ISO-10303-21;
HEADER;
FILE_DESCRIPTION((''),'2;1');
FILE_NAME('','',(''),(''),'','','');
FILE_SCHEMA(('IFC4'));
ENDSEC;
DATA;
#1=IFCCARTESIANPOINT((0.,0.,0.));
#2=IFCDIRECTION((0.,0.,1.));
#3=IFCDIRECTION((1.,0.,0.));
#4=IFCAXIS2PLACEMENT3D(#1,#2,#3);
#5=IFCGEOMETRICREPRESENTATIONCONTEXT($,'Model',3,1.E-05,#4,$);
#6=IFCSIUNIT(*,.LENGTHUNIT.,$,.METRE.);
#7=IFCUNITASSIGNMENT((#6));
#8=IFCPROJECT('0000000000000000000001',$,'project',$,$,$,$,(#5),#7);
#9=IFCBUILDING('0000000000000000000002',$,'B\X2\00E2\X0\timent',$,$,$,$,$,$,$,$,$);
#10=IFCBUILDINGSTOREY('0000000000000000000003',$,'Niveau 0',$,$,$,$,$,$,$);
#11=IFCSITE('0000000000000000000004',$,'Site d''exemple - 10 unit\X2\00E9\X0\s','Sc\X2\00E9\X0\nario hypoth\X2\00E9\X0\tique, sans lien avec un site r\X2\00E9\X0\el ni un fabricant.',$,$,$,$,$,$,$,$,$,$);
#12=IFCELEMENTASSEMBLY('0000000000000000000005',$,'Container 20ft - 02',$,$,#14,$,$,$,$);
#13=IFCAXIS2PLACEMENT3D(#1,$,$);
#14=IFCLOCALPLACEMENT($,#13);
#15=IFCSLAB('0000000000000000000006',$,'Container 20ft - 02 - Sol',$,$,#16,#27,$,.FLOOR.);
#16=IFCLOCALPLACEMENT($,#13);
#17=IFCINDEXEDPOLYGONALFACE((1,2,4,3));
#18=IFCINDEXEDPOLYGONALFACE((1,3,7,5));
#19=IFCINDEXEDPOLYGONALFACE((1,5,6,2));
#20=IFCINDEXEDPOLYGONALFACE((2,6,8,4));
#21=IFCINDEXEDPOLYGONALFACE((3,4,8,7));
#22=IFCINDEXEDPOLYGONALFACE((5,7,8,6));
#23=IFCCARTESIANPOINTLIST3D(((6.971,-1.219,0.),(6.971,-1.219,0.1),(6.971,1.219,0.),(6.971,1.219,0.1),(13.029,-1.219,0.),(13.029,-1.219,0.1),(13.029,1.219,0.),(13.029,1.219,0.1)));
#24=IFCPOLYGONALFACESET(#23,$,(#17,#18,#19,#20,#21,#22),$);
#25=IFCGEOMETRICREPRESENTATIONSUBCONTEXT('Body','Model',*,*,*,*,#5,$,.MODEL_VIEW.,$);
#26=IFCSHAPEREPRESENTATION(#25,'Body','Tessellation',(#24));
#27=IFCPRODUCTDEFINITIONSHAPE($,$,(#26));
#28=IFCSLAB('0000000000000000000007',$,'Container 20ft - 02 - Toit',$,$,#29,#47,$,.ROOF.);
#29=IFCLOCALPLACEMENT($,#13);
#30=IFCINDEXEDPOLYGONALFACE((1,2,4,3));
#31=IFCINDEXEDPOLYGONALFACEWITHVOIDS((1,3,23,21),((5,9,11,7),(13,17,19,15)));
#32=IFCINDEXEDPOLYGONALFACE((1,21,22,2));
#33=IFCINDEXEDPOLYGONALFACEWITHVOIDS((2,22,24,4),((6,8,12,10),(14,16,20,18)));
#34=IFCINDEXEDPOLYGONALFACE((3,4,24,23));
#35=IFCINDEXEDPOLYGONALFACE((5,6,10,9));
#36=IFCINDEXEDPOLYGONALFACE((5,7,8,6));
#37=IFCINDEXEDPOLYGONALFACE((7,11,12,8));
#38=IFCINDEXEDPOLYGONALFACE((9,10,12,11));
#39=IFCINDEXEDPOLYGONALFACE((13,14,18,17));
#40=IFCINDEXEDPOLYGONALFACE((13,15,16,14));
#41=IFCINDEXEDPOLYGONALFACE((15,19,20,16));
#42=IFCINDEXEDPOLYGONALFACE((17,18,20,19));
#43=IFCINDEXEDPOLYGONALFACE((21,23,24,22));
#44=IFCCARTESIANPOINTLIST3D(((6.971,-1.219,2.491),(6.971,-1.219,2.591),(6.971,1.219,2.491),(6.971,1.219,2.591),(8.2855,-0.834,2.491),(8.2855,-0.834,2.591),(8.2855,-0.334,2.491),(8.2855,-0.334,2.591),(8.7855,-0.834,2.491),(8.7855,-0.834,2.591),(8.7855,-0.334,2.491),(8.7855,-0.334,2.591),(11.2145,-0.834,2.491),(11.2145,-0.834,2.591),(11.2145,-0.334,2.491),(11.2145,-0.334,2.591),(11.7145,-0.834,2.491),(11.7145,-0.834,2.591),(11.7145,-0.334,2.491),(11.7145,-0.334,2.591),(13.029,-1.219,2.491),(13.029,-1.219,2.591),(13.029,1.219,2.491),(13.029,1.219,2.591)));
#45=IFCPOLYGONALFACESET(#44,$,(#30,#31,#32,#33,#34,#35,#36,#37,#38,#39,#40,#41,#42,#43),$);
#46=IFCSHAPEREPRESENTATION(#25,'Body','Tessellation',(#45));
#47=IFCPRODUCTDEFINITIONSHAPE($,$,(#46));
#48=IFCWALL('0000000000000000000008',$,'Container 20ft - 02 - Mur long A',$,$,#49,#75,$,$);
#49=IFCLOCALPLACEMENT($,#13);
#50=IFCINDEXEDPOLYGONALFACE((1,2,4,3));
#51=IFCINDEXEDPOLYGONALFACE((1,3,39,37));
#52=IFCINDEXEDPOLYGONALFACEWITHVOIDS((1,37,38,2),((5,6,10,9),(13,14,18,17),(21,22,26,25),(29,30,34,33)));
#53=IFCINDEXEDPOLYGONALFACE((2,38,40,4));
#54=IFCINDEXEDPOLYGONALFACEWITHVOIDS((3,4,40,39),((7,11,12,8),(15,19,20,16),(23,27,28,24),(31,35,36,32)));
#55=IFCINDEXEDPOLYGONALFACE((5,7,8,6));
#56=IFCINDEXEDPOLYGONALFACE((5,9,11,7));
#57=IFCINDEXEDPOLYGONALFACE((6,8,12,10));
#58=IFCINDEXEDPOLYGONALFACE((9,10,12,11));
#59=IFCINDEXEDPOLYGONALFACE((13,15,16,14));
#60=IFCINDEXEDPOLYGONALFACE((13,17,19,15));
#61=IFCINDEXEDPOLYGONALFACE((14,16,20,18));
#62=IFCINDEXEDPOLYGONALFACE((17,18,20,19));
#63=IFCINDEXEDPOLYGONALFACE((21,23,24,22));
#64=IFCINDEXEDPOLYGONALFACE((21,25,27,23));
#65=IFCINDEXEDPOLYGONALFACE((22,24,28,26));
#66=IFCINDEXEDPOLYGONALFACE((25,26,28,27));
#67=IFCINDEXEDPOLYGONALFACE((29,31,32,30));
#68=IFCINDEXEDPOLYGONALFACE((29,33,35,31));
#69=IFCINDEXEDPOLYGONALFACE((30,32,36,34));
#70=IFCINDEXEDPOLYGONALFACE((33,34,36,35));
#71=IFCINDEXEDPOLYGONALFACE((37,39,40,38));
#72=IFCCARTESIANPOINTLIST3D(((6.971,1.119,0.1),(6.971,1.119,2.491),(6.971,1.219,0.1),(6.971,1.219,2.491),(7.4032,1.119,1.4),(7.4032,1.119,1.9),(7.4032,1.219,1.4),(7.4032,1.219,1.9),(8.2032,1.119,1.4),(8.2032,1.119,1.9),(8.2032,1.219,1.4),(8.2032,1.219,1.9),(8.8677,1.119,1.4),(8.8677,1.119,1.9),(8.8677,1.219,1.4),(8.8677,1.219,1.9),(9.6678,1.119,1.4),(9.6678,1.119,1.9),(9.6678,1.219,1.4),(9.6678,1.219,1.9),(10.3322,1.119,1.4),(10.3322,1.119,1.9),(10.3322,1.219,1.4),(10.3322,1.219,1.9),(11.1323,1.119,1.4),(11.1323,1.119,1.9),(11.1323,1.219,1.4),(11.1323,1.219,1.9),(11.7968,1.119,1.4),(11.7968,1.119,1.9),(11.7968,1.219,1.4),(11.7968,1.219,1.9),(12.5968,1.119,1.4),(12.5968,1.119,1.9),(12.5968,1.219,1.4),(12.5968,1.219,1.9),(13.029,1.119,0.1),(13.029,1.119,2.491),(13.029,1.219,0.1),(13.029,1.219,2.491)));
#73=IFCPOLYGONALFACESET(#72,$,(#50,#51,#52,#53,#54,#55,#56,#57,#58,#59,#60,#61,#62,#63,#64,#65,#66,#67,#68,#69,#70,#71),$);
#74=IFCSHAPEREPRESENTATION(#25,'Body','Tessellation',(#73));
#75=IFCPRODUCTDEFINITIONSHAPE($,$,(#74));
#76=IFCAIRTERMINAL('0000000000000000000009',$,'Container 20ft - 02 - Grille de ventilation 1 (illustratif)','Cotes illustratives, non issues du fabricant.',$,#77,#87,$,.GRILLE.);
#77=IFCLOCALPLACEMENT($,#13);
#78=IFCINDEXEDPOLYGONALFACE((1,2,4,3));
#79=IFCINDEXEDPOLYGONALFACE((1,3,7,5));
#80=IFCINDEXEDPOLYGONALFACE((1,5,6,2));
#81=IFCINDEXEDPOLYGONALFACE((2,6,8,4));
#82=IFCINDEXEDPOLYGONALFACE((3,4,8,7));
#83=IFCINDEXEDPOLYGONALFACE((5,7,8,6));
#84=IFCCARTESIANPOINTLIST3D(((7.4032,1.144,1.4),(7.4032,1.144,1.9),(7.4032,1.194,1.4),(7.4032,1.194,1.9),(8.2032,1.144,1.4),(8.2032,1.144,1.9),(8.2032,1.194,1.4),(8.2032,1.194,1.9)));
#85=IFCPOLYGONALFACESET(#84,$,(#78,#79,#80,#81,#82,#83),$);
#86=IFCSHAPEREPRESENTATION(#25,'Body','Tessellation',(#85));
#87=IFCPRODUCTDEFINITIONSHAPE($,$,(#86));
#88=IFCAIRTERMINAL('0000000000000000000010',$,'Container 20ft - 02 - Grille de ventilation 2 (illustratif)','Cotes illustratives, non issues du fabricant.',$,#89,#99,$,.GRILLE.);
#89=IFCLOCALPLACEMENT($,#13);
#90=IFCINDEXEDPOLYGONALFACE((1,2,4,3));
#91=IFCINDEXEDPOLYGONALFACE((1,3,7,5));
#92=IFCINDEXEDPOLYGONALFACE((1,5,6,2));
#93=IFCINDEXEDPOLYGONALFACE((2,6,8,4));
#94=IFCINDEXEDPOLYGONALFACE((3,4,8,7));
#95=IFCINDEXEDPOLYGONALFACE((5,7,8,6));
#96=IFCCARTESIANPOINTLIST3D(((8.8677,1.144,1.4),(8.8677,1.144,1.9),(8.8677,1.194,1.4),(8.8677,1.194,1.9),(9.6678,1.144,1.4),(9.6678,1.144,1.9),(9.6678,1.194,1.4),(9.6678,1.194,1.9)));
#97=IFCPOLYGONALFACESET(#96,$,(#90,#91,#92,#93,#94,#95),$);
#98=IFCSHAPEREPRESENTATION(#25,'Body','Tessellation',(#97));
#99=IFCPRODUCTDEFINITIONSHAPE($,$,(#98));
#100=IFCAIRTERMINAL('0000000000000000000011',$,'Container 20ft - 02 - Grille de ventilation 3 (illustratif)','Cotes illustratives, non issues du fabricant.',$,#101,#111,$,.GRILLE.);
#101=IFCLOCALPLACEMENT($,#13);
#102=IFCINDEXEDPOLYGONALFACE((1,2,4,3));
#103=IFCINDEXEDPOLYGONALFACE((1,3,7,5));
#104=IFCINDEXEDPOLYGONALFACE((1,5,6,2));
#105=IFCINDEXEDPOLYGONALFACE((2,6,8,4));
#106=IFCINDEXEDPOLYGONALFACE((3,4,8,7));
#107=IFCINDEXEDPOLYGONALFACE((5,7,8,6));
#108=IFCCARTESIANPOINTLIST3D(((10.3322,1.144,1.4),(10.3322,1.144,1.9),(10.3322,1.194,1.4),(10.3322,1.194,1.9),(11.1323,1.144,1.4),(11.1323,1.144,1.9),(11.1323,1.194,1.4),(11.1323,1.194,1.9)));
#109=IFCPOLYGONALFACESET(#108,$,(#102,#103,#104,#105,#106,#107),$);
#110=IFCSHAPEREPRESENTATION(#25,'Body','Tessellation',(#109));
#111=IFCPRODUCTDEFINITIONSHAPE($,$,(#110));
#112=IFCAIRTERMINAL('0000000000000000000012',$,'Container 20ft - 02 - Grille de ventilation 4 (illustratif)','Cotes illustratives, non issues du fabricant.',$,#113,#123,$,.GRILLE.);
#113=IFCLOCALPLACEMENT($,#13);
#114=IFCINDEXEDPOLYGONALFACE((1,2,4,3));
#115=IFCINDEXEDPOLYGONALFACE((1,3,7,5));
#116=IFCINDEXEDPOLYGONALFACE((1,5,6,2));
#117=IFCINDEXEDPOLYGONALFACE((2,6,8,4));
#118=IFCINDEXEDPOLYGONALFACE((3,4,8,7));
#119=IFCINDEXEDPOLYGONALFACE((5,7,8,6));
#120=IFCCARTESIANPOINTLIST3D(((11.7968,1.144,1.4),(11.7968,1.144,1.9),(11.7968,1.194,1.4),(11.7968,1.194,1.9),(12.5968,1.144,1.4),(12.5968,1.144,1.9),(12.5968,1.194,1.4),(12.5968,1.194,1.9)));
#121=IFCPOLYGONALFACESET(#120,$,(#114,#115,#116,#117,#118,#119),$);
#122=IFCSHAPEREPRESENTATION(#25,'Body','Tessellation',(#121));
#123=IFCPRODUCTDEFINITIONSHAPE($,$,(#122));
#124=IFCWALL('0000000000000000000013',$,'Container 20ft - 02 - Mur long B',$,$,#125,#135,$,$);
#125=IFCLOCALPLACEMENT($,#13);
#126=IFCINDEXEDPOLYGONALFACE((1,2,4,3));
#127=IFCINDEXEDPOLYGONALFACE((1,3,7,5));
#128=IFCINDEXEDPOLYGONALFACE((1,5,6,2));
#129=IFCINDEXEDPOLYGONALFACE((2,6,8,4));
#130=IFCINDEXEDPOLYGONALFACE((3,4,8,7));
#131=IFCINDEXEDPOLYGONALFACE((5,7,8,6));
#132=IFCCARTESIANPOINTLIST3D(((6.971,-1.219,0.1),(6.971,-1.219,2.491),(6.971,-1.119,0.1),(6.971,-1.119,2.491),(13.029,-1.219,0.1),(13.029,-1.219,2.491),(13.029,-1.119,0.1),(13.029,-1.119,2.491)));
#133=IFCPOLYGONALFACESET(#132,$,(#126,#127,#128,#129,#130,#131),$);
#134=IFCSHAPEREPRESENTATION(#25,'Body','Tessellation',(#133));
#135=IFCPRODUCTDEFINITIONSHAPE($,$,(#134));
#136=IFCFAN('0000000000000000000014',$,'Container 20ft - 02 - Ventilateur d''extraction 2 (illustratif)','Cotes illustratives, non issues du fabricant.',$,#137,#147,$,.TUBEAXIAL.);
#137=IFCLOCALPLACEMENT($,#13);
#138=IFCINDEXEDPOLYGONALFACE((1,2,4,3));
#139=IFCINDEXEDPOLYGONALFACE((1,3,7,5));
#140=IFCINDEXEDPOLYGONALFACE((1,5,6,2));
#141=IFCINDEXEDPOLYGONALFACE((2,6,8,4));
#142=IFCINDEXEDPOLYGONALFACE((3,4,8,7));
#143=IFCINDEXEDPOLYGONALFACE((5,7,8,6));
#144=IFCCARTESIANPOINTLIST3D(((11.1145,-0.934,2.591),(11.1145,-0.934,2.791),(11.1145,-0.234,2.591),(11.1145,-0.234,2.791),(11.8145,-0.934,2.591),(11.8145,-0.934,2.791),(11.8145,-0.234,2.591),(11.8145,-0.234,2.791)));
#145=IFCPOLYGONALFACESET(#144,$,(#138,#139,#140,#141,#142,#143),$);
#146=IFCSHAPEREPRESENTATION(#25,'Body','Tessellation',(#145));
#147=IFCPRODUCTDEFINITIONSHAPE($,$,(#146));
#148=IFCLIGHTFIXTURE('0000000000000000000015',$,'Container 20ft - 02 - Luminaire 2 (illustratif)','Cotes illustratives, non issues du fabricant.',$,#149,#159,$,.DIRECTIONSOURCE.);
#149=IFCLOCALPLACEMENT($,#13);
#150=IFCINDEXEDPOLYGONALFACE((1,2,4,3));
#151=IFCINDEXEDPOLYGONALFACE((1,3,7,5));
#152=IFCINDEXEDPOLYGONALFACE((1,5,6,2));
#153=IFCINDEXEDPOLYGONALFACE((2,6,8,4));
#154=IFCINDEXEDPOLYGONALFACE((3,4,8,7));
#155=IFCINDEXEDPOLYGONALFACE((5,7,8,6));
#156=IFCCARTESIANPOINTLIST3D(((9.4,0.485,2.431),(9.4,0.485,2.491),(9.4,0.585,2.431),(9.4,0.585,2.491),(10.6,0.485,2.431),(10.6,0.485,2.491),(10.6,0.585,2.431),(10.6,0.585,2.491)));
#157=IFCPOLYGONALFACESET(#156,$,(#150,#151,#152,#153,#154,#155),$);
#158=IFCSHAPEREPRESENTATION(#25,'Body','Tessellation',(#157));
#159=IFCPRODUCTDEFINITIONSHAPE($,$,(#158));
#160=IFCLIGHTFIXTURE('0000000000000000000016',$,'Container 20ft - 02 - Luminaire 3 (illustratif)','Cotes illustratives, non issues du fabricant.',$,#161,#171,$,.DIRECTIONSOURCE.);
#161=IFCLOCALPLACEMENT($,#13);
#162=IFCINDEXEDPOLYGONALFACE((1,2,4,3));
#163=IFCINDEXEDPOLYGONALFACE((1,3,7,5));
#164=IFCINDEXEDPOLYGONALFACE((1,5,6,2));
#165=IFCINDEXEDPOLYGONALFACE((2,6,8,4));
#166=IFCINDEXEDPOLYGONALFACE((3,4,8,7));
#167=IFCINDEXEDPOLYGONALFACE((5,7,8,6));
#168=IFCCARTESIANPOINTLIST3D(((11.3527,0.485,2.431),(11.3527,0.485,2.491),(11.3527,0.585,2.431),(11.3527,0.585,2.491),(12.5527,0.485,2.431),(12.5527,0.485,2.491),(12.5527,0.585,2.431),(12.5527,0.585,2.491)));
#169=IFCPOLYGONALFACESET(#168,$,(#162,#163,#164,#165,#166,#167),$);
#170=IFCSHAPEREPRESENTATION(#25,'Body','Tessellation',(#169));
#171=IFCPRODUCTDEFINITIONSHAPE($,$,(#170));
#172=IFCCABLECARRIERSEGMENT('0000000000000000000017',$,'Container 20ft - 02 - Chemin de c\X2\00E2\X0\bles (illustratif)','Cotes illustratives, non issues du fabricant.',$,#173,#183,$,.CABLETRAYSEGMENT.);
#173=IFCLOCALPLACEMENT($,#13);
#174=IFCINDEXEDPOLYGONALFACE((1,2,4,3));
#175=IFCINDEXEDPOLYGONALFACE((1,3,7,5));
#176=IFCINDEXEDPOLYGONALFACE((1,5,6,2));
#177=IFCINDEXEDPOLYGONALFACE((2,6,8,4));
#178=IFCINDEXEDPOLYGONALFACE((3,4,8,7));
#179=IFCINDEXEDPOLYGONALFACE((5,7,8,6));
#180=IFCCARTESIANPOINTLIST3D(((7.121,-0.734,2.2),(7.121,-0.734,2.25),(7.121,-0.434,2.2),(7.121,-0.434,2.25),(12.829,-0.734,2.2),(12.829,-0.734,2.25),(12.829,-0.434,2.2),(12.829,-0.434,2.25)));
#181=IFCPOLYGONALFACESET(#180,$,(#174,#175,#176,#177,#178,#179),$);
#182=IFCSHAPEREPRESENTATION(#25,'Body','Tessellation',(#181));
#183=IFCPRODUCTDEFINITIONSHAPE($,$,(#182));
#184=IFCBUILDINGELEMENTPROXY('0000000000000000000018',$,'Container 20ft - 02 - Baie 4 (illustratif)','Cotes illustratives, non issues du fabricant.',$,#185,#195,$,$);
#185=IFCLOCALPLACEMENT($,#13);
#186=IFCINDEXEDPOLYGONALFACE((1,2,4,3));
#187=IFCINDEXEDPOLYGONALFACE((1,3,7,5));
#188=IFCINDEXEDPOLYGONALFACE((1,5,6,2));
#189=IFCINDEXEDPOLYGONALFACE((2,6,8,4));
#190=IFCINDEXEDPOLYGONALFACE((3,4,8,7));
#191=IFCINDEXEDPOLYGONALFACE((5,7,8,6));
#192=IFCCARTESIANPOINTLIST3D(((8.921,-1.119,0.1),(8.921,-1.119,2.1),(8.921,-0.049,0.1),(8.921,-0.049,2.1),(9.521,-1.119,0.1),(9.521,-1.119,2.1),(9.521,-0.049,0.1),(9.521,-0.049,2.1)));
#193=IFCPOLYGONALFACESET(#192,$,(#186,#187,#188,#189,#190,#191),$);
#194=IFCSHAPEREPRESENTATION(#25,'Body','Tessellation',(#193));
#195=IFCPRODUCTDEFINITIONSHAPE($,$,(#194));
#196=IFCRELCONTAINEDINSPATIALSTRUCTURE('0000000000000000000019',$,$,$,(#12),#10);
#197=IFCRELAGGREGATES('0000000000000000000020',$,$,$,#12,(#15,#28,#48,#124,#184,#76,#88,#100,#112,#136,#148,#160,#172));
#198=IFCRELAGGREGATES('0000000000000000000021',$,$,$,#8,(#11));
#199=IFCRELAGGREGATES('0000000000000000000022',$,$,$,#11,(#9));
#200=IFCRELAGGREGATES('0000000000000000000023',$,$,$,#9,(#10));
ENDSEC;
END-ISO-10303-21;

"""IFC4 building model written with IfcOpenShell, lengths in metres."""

from ifc_helpers import new_model, si_unit, frame, origin_with_axes, place, context, subcontext, project, spatial, rectangle, extrude, element, fill, aggregate, save


model = new_model("IFC4")

# Units and contexts
model_context = context("Model", 3, precision=1e-05, world=origin_with_axes())
body_context = subcontext(model_context, "Body", "Model", "MODEL_VIEW")
ifc_project = project(units=[si_unit("LENGTHUNIT", "METRE")], contexts=[model_context])

# Site, building, storey
site = spatial("IfcSite", under=ifc_project, Name="Site d'exemple - 10 unités", Description="Scénario hypothétique, sans lien avec un site réel ni un fabricant.")
building = spatial("IfcBuilding", under=site, Name="Bâtiment")
storey = spatial("IfcBuildingStorey", under=building, Name="Niveau 0")

# Element assembly, slabs, openings, walls, air terminals, fan, light fixtures, cable carrier segment, building element proxy
assembly = element("IfcElementAssembly", 1, inside=storey, Name="Container 20ft - 02")
slab_1_placement = place(None, frame((10.0, 0.0, 0.0), z_axis=(0.0, 0.0, 1.0), x_axis=(1.0, 0.0, 0.0)))
slab_1 = element("IfcSlab", 2, at=slab_1_placement, Name="Container 20ft - 02 - Sol", PredefinedType="FLOOR", context=body_context, shape_type="SweptSolid", body=[
    extrude(rectangle(XDim=6.058, YDim=2.438), origin_with_axes(), (0.0, 0.0, 1.0), 0.1),
])
slab_2_placement = place(None, frame((10.0, 0.0, 2.491), z_axis=(0.0, 0.0, 1.0), x_axis=(1.0, 0.0, 0.0)))
slab_2 = element("IfcSlab", 3, at=slab_2_placement, Name="Container 20ft - 02 - Toit", PredefinedType="ROOF", context=body_context, shape_type="SweptSolid", body=[
    extrude(rectangle(XDim=6.058, YDim=2.438), origin_with_axes(), (0.0, 0.0, 1.0), 0.1),
])
opening_1_placement = place(None, frame((8.5355, -0.584, 2.441), z_axis=(0.0, 0.0, 1.0), x_axis=(1.0, 0.0, 0.0)))
element("IfcOpeningElement", 4, at=opening_1_placement, cuts=slab_2, PredefinedType="OPENING", context=body_context, shape_type="SweptSolid", body=[
    extrude(rectangle(XDim=0.5, YDim=0.5), origin_with_axes(), (0.0, 0.0, 1.0), 0.2),
])
opening_2_placement = place(None, frame((11.4645, -0.584, 2.441), z_axis=(0.0, 0.0, 1.0), x_axis=(1.0, 0.0, 0.0)))
element("IfcOpeningElement", 5, at=opening_2_placement, cuts=slab_2, PredefinedType="OPENING", context=body_context, shape_type="SweptSolid", body=[
    extrude(rectangle(XDim=0.5, YDim=0.5), origin_with_axes(), (0.0, 0.0, 1.0), 0.2),
])
wall_1_placement = place(None, frame((10.0, 1.169, 0.1), z_axis=(0.0, 0.0, 1.0), x_axis=(1.0, 0.0, 0.0)))
wall_1 = element("IfcWall", 6, at=wall_1_placement, Name="Container 20ft - 02 - Mur long A", context=body_context, shape_type="SweptSolid", body=[
    extrude(rectangle(XDim=6.058, YDim=0.1), origin_with_axes(), (0.0, 0.0, 1.0), 2.391),
])
opening_3_placement = place(None, frame((7.8033, 1.169, 1.4), z_axis=(0.0, 0.0, 1.0), x_axis=(1.0, 0.0, 0.0)))
opening_3 = element("IfcOpeningElement", 7, at=opening_3_placement, cuts=wall_1, PredefinedType="OPENING", context=body_context, shape_type="SweptSolid", body=[
    extrude(rectangle(XDim=0.8, YDim=0.2), origin_with_axes(), (0.0, 0.0, 1.0), 0.5),
])
opening_4_placement = place(None, frame((9.2677, 1.169, 1.4), z_axis=(0.0, 0.0, 1.0), x_axis=(1.0, 0.0, 0.0)))
opening_4 = element("IfcOpeningElement", 8, at=opening_4_placement, cuts=wall_1, PredefinedType="OPENING", context=body_context, shape_type="SweptSolid", body=[
    extrude(rectangle(XDim=0.8, YDim=0.2), origin_with_axes(), (0.0, 0.0, 1.0), 0.5),
])
opening_5_placement = place(None, frame((10.7323, 1.169, 1.4), z_axis=(0.0, 0.0, 1.0), x_axis=(1.0, 0.0, 0.0)))
opening_5 = element("IfcOpeningElement", 9, at=opening_5_placement, cuts=wall_1, PredefinedType="OPENING", context=body_context, shape_type="SweptSolid", body=[
    extrude(rectangle(XDim=0.8, YDim=0.2), origin_with_axes(), (0.0, 0.0, 1.0), 0.5),
])
opening_6_placement = place(None, frame((12.1967, 1.169, 1.4), z_axis=(0.0, 0.0, 1.0), x_axis=(1.0, 0.0, 0.0)))
opening_6 = element("IfcOpeningElement", 10, at=opening_6_placement, cuts=wall_1, PredefinedType="OPENING", context=body_context, shape_type="SweptSolid", body=[
    extrude(rectangle(XDim=0.8, YDim=0.2), origin_with_axes(), (0.0, 0.0, 1.0), 0.5),
])
air_terminal_1_placement = place(None, frame((7.8033, 1.169, 1.4), z_axis=(0.0, 0.0, 1.0), x_axis=(1.0, 0.0, 0.0)))
air_terminal_1 = element("IfcAirTerminal", 11, at=air_terminal_1_placement, Name="Container 20ft - 02 - Grille de ventilation 1 (illustratif)", Description="Cotes illustratives, non issues du fabricant.", PredefinedType="GRILLE", context=body_context, shape_type="SweptSolid", body=[
    extrude(rectangle(XDim=0.8, YDim=0.05), origin_with_axes(), (0.0, 0.0, 1.0), 0.5),
])
fill(opening_3, air_terminal_1)
air_terminal_2_placement = place(None, frame((9.2677, 1.169, 1.4), z_axis=(0.0, 0.0, 1.0), x_axis=(1.0, 0.0, 0.0)))
air_terminal_2 = element("IfcAirTerminal", 12, at=air_terminal_2_placement, Name="Container 20ft - 02 - Grille de ventilation 2 (illustratif)", Description="Cotes illustratives, non issues du fabricant.", PredefinedType="GRILLE", context=body_context, shape_type="SweptSolid", body=[
    extrude(rectangle(XDim=0.8, YDim=0.05), origin_with_axes(), (0.0, 0.0, 1.0), 0.5),
])
fill(opening_4, air_terminal_2)
air_terminal_3_placement = place(None, frame((10.7323, 1.169, 1.4), z_axis=(0.0, 0.0, 1.0), x_axis=(1.0, 0.0, 0.0)))
air_terminal_3 = element("IfcAirTerminal", 13, at=air_terminal_3_placement, Name="Container 20ft - 02 - Grille de ventilation 3 (illustratif)", Description="Cotes illustratives, non issues du fabricant.", PredefinedType="GRILLE", context=body_context, shape_type="SweptSolid", body=[
    extrude(rectangle(XDim=0.8, YDim=0.05), origin_with_axes(), (0.0, 0.0, 1.0), 0.5),
])
fill(opening_5, air_terminal_3)
air_terminal_4_placement = place(None, frame((12.1967, 1.169, 1.4), z_axis=(0.0, 0.0, 1.0), x_axis=(1.0, 0.0, 0.0)))
air_terminal_4 = element("IfcAirTerminal", 14, at=air_terminal_4_placement, Name="Container 20ft - 02 - Grille de ventilation 4 (illustratif)", Description="Cotes illustratives, non issues du fabricant.", PredefinedType="GRILLE", context=body_context, shape_type="SweptSolid", body=[
    extrude(rectangle(XDim=0.8, YDim=0.05), origin_with_axes(), (0.0, 0.0, 1.0), 0.5),
])
fill(opening_6, air_terminal_4)
wall_2_placement = place(None, frame((10.0, -1.169, 0.1), z_axis=(0.0, 0.0, 1.0), x_axis=(1.0, 0.0, 0.0)))
wall_2 = element("IfcWall", 15, at=wall_2_placement, Name="Container 20ft - 02 - Mur long B", context=body_context, shape_type="SweptSolid", body=[
    extrude(rectangle(XDim=6.058, YDim=0.1), origin_with_axes(), (0.0, 0.0, 1.0), 2.391),
])
fan_placement = place(None, frame((11.4645, -0.584, 2.591), z_axis=(0.0, 0.0, 1.0), x_axis=(1.0, 0.0, 0.0)))
fan = element("IfcFan", 16, at=fan_placement, Name="Container 20ft - 02 - Ventilateur d'extraction 2 (illustratif)", Description="Cotes illustratives, non issues du fabricant.", PredefinedType="TUBEAXIAL", context=body_context, shape_type="SweptSolid", body=[
    extrude(rectangle(XDim=0.7, YDim=0.7), origin_with_axes(), (0.0, 0.0, 1.0), 0.2),
])
light_fixture_1_placement = place(None, frame((10.0, 0.535, 2.431), z_axis=(0.0, 0.0, 1.0), x_axis=(1.0, 0.0, 0.0)))
light_fixture_1 = element("IfcLightFixture", 17, at=light_fixture_1_placement, Name="Container 20ft - 02 - Luminaire 2 (illustratif)", Description="Cotes illustratives, non issues du fabricant.", PredefinedType="DIRECTIONSOURCE", context=body_context, shape_type="SweptSolid", body=[
    extrude(rectangle(XDim=1.2, YDim=0.1), origin_with_axes(), (0.0, 0.0, 1.0), 0.06),
])
light_fixture_2_placement = place(None, frame((11.9527, 0.535, 2.431), z_axis=(0.0, 0.0, 1.0), x_axis=(1.0, 0.0, 0.0)))
light_fixture_2 = element("IfcLightFixture", 18, at=light_fixture_2_placement, Name="Container 20ft - 02 - Luminaire 3 (illustratif)", Description="Cotes illustratives, non issues du fabricant.", PredefinedType="DIRECTIONSOURCE", context=body_context, shape_type="SweptSolid", body=[
    extrude(rectangle(XDim=1.2, YDim=0.1), origin_with_axes(), (0.0, 0.0, 1.0), 0.06),
])
cable_carrier_segment_placement = place(None, frame((9.975, -0.584, 2.2), z_axis=(0.0, 0.0, 1.0), x_axis=(1.0, 0.0, 0.0)))
cable_carrier_segment = element("IfcCableCarrierSegment", 19, at=cable_carrier_segment_placement, Name="Container 20ft - 02 - Chemin de câbles (illustratif)", Description="Cotes illustratives, non issues du fabricant.", PredefinedType="CABLETRAYSEGMENT", context=body_context, shape_type="SweptSolid", body=[
    extrude(rectangle(XDim=5.708, YDim=0.3), origin_with_axes(), (0.0, 0.0, 1.0), 0.05),
])
proxy_1_placement = place(None, frame((9.221, -0.584, 0.1), z_axis=(0.0, 0.0, 1.0), x_axis=(1.0, 0.0, 0.0)))
proxy_1 = element("IfcBuildingElementProxy", 20, at=proxy_1_placement, Name="Container 20ft - 02 - Baie 4 (illustratif)", Description="Cotes illustratives, non issues du fabricant.", context=body_context, shape_type="SweptSolid", body=[
    extrude(rectangle(XDim=0.6, YDim=1.07), origin_with_axes(), (0.0, 0.0, 1.0), 2.0),
])
aggregate(assembly, [slab_1, slab_2, wall_1, wall_2, proxy_1, air_terminal_1, air_terminal_2, air_terminal_3, air_terminal_4, fan, light_fixture_1, light_fixture_2, cable_carrier_segment])

save(model, "model.ifc")
